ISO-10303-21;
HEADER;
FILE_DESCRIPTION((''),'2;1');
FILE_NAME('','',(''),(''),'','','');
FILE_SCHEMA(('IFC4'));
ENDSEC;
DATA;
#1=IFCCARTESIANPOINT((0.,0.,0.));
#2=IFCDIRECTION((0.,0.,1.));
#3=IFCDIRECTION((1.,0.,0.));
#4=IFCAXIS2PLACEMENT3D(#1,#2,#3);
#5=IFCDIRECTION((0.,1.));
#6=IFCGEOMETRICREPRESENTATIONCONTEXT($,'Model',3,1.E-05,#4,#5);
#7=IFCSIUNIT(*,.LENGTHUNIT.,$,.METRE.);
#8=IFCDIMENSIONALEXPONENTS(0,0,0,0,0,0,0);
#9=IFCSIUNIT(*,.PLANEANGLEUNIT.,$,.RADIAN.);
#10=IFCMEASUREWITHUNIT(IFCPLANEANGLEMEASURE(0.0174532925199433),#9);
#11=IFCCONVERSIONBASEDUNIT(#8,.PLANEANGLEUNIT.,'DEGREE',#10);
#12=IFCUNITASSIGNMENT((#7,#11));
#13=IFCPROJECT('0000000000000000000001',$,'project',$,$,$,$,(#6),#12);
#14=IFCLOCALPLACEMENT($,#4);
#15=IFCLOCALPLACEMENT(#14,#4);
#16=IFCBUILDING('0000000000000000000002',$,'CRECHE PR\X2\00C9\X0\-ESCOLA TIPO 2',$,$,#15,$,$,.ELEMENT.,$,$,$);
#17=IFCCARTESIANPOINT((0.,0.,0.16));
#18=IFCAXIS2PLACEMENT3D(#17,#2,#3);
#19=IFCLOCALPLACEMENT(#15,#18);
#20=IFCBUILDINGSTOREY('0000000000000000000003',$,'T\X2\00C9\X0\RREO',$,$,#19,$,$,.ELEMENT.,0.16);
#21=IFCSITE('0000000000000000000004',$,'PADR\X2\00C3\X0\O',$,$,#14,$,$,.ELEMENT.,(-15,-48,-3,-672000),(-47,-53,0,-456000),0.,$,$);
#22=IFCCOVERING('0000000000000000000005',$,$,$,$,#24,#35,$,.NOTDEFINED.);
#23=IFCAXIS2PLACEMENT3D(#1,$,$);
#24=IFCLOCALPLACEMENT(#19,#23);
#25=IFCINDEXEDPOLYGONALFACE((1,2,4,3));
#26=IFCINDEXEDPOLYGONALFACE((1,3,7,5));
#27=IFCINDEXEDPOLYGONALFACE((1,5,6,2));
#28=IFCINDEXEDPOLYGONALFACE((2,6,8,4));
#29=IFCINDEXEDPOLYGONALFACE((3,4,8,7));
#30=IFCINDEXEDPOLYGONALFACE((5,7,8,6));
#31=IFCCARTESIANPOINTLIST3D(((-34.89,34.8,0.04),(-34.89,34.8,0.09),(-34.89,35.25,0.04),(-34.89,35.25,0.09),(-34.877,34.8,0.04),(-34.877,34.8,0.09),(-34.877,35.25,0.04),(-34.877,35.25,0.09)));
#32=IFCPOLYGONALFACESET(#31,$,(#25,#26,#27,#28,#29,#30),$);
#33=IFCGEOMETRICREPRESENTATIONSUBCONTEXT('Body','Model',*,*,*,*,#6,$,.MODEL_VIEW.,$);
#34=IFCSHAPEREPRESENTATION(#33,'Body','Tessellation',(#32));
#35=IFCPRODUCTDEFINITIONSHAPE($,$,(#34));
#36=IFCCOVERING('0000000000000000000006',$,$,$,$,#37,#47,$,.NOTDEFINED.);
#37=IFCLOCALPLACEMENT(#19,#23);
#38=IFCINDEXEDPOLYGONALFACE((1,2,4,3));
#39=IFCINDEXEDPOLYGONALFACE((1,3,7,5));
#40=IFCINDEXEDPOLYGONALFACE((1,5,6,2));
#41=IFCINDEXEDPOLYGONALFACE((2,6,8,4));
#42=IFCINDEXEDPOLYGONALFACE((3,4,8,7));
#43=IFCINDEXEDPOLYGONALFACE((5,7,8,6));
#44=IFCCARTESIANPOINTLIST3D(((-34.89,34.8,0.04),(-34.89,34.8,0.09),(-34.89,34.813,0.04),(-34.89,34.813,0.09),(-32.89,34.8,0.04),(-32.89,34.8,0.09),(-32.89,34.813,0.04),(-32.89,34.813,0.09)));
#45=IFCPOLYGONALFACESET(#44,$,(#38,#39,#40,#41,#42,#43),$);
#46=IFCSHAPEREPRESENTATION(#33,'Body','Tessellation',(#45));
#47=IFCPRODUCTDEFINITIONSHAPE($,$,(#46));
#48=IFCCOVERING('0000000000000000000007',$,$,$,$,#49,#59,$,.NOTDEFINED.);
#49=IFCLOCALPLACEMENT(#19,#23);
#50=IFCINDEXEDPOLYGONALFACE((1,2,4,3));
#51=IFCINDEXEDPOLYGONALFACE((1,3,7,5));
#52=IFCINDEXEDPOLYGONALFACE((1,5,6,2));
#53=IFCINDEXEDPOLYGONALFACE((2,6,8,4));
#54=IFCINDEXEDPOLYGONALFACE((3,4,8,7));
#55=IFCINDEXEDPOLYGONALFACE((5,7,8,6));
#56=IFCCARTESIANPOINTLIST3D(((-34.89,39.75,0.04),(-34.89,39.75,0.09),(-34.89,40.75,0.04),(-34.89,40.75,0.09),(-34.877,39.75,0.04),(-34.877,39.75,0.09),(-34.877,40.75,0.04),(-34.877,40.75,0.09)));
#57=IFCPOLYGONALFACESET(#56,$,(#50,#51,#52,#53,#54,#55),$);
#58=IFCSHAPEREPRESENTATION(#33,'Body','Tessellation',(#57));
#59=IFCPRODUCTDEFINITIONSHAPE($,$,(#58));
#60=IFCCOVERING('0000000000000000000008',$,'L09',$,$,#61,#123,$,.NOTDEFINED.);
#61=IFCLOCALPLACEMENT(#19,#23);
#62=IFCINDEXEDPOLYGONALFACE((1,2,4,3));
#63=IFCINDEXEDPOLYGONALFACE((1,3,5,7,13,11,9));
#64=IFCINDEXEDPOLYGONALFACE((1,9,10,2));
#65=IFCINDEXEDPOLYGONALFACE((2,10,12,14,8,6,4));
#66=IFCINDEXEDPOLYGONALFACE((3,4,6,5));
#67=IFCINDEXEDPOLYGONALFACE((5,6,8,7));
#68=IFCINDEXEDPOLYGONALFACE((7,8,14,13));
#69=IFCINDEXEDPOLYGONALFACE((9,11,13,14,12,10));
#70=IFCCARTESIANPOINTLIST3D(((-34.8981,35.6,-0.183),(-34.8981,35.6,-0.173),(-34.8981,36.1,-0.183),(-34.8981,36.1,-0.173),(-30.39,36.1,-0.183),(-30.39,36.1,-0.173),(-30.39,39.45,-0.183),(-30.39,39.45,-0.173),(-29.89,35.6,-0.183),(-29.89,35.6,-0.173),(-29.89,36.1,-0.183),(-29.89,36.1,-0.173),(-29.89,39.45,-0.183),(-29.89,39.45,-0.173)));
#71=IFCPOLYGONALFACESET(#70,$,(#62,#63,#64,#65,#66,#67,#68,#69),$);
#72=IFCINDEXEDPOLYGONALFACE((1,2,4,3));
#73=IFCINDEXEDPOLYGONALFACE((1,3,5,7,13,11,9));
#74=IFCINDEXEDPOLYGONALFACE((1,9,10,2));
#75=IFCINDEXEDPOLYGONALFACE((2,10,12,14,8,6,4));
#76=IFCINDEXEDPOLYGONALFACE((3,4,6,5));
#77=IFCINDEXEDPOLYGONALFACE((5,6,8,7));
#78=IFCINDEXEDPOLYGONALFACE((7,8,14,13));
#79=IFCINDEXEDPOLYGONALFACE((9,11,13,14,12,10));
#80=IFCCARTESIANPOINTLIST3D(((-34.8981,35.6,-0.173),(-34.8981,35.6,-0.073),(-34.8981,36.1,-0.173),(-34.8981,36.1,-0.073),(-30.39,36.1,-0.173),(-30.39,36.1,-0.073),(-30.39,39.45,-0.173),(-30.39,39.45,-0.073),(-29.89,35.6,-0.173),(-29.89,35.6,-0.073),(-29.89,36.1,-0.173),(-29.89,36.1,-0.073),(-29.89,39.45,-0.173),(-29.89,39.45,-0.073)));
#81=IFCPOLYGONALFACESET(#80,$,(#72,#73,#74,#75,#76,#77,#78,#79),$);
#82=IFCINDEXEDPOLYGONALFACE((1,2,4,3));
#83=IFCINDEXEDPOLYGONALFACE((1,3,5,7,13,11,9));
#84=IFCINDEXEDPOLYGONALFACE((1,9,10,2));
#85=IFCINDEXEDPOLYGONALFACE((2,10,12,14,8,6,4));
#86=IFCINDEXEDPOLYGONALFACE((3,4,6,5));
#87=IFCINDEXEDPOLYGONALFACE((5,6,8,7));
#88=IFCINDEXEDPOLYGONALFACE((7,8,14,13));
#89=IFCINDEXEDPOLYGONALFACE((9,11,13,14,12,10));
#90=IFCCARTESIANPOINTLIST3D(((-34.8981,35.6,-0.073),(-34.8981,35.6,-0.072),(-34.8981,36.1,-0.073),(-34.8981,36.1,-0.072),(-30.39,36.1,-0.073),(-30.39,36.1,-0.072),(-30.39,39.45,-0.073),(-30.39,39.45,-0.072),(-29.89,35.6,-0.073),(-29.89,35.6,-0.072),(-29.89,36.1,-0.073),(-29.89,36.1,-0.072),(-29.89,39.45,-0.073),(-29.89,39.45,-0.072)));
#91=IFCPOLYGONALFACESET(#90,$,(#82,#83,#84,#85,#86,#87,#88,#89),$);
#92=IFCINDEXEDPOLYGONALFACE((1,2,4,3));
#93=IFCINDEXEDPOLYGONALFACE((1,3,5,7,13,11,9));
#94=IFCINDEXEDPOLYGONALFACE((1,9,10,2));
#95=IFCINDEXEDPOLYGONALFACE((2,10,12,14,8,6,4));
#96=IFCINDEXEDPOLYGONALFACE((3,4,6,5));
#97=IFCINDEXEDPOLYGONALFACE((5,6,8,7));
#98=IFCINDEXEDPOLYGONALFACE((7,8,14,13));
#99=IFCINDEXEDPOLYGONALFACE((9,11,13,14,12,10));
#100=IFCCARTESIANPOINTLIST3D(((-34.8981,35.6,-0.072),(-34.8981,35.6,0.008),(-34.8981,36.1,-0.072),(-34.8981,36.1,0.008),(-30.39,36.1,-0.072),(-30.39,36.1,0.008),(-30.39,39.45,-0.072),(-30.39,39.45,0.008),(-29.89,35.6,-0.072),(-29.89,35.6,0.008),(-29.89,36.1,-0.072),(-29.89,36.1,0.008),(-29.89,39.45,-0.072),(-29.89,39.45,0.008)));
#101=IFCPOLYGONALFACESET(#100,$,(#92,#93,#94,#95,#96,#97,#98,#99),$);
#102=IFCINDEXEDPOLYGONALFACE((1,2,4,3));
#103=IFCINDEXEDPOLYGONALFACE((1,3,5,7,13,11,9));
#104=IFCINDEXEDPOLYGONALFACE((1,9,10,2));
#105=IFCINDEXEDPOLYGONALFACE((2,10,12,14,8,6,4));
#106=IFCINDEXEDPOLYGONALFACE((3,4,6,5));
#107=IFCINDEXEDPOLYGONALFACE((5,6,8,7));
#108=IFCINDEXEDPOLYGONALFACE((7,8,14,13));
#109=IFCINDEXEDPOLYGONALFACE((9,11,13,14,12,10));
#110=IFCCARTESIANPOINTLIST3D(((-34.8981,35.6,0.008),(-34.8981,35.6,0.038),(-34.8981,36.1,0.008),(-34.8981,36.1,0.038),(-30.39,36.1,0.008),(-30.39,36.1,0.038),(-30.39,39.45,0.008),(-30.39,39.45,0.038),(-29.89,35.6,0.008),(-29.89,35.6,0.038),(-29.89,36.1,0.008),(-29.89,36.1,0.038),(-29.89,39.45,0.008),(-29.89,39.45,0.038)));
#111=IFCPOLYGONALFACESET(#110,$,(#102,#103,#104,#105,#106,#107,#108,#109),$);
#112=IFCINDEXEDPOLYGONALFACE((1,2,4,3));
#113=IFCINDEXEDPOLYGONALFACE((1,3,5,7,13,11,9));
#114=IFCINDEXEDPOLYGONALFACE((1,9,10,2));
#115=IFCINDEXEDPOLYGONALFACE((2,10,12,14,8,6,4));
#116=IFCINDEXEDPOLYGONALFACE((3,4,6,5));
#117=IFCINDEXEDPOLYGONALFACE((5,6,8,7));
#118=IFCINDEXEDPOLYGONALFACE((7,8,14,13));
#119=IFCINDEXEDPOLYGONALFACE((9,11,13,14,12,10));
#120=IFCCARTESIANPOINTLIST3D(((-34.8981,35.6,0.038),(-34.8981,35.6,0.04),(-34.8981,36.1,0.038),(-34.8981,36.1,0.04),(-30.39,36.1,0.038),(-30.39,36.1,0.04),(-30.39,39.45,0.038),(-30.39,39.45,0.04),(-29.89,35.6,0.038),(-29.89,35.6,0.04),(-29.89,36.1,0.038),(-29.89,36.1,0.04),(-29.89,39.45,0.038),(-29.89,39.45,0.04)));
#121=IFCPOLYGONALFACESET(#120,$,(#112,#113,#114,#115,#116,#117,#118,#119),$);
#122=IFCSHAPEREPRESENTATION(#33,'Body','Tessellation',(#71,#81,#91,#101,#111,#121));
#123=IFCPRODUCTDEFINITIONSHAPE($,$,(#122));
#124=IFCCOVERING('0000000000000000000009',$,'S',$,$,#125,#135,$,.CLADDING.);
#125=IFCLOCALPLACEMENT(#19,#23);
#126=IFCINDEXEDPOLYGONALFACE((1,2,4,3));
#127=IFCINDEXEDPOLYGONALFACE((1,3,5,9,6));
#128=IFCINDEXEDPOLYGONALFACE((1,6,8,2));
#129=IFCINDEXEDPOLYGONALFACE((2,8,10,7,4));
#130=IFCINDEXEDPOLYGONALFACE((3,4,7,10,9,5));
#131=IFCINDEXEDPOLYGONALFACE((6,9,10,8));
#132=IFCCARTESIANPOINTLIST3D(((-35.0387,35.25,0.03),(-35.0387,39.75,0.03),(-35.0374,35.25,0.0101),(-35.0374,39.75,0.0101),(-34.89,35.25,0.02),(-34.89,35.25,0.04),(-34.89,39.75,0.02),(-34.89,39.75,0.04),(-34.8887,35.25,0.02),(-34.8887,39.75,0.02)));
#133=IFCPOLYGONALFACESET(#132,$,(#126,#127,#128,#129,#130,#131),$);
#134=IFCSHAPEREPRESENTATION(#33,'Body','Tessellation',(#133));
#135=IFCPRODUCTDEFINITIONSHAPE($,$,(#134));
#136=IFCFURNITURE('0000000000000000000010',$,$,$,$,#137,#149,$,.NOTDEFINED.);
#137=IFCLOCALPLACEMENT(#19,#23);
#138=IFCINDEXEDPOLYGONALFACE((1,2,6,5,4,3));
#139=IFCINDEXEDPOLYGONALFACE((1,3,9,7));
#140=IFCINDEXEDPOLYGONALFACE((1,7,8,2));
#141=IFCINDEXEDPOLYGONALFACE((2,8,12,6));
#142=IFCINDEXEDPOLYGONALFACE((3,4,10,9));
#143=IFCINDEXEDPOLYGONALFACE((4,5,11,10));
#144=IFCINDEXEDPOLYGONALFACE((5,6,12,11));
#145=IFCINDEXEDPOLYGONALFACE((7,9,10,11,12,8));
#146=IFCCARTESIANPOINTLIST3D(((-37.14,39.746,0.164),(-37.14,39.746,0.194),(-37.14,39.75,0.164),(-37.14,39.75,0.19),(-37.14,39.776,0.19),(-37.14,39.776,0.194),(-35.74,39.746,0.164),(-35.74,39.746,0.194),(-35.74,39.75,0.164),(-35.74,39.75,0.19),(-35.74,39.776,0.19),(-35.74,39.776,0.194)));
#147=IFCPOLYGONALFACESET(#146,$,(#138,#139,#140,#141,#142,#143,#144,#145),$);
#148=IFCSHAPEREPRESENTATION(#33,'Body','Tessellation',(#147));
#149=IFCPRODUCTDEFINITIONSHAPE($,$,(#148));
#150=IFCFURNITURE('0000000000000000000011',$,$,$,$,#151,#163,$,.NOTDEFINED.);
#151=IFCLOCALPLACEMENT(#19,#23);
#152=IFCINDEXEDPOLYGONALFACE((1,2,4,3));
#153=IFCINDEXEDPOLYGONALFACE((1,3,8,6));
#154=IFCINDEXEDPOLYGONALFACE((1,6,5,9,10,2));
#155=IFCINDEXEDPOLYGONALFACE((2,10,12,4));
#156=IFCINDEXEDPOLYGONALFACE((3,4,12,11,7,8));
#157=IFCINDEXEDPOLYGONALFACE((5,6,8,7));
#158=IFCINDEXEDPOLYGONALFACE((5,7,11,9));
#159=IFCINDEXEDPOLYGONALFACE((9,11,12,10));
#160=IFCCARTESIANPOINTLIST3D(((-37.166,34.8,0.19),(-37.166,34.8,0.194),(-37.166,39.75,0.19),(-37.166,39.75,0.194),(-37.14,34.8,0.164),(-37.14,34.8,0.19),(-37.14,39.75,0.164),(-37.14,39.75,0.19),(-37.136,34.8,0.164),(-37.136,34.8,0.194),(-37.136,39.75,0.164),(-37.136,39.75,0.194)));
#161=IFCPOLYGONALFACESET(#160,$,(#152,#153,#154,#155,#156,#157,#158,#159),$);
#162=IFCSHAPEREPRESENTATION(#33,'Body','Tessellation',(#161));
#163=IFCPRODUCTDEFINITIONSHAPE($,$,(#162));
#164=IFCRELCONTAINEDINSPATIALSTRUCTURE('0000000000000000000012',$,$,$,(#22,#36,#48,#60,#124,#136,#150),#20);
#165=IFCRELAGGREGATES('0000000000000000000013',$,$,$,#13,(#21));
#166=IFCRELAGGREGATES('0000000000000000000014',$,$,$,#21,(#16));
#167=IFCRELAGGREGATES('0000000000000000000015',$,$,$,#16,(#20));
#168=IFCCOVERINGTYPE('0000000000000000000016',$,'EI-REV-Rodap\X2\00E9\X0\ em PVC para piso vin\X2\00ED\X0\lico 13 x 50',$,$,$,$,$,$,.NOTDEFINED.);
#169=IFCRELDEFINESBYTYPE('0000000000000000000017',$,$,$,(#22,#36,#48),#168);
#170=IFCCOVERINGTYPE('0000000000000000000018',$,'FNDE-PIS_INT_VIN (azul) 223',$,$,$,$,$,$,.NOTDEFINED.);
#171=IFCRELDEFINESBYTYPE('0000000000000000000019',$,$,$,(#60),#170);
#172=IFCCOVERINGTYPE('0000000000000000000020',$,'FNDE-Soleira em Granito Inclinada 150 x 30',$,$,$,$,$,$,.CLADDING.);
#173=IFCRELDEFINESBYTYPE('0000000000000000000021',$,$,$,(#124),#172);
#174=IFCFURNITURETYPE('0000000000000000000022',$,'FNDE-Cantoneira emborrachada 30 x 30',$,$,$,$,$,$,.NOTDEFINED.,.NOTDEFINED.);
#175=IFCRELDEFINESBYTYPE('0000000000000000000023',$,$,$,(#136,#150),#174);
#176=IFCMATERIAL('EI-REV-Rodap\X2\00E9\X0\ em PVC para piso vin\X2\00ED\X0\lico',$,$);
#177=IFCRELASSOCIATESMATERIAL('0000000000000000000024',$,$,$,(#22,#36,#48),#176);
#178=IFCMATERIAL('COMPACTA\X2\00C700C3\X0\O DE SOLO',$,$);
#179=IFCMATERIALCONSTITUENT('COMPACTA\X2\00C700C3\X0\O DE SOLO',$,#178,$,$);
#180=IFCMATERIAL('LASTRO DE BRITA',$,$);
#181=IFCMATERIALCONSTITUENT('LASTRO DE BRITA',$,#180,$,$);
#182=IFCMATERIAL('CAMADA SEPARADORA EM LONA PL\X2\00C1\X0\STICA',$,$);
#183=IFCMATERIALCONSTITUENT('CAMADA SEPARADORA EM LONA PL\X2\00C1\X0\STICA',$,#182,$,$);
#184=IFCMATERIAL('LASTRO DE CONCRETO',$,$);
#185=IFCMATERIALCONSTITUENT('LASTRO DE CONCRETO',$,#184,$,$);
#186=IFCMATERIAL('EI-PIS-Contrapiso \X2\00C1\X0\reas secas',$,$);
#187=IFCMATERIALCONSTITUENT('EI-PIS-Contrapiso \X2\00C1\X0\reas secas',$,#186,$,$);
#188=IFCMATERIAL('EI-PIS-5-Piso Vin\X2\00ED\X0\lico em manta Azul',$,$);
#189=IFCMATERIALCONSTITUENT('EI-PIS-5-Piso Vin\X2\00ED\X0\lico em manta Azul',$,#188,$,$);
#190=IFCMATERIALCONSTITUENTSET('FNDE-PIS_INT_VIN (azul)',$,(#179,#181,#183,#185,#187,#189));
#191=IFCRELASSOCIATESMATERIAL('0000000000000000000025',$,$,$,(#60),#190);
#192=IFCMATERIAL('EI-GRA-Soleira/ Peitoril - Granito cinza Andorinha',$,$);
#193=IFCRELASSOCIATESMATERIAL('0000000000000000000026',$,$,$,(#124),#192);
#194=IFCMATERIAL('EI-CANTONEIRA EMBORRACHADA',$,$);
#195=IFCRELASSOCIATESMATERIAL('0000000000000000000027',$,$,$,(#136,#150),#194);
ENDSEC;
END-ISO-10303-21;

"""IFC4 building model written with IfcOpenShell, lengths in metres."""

from ifc_helpers import new_model, entity, si_unit, converted_unit, direction, frame, frame_2d, origin_with_axes, place, context, subcontext, project, spatial, line, indexed_curve, rectangle, outline, extrude, material, constituent, constituent_set, material_profile, profile_set, type_object, element, save


model = new_model("IFC4")

# Units and contexts
model_context = context("Model", 3, precision=1e-05, world=origin_with_axes(), true_north=direction((0.0, 1.0)))
body_context = subcontext(model_context, "Body", "Model", "MODEL_VIEW")
ifc_project = project(units=[si_unit("LENGTHUNIT", "METRE"), converted_unit("PLANEANGLEUNIT", "DEGREE", entity("IfcPlaneAngleMeasure", 0.0174532925199433), si_unit("PLANEANGLEUNIT", "RADIAN"), dimensions=[0, 0, 0, 0, 0, 0, 0])], contexts=[model_context])

# Site, building, storey
site_placement = place(None, origin_with_axes())
site = spatial("IfcSite", under=ifc_project, at=site_placement, Name="PADRÃO", CompositionType="ELEMENT", RefLatitude=(-15, -48, -3, -672000), RefLongitude=(-47, -53, 0, -456000), RefElevation=0.0)
building_placement = place(site_placement, origin_with_axes())
building = spatial("IfcBuilding", under=site, at=building_placement, Name="CRECHE PRÉ-ESCOLA TIPO 2", CompositionType="ELEMENT")
storey_placement = place(building_placement, frame((0.0, 0.0, 0.16), z_axis=(0.0, 0.0, 1.0), x_axis=(1.0, 0.0, 0.0)))
storey = spatial("IfcBuildingStorey", under=building, at=storey_placement, Name="TÉRREO", CompositionType="ELEMENT", Elevation=0.16)

# Coverings
ifc_material_1 = material(Name="COMPACTAÇÃO DE SOLO")
ifc_material_2 = material(Name="LASTRO DE BRITA")
ifc_material_3 = material(Name="CAMADA SEPARADORA EM LONA PLÁSTICA")
ifc_material_4 = material(Name="LASTRO DE CONCRETO")
ifc_material_5 = material(Name="EI-PIS-Contrapiso Áreas secas")
ifc_material_6 = material(Name="EI-REV-Rodapé em PVC para piso vinílico")
covering_type_1 = type_object("IfcCoveringType", Name="EI-REV-Rodapé em PVC para piso vinílico 13 x 50", PredefinedType="NOTDEFINED")
covering_1_placement = place(storey_placement, frame((-34.89, 35.25, 0.04), z_axis=(0.0, 0.0, 1.0), x_axis=(-1.0, 0.0, 0.0)))
element("IfcCovering", 1, at=covering_1_placement, inside=storey, type_object=covering_type_1, material=ifc_material_6, PredefinedType="NOTDEFINED", context=body_context, shape_type="SweptSolid", body=[
    extrude(rectangle(XDim=0.05, YDim=0.013, at=frame_2d((0.025, -0.0065), x_axis=(1.0, 0.0))), frame((0.0, 0.0, 0.0), z_axis=(0.0, 1.0, 0.0), x_axis=(0.0, 0.0, 1.0)), (0.0, 0.0, 1.0), 0.45),
])
covering_2_placement = place(storey_placement, frame((-34.89, 34.8, 0.04), z_axis=(0.0, 0.0, 1.0), x_axis=(0.0, -1.0, 0.0)))
element("IfcCovering", 2, at=covering_2_placement, inside=storey, type_object=covering_type_1, material=ifc_material_6, PredefinedType="NOTDEFINED", context=body_context, shape_type="SweptSolid", body=[
    extrude(rectangle(XDim=0.05, YDim=0.013, at=frame_2d((0.025, -0.0065), x_axis=(1.0, 0.0))), frame((0.0, 0.0, 0.0), z_axis=(0.0, 1.0, 0.0), x_axis=(0.0, 0.0, 1.0)), (0.0, 0.0, 1.0), 2.0),
])
covering_3_placement = place(storey_placement, frame((-34.89, 40.75, 0.04), z_axis=(0.0, 0.0, 1.0), x_axis=(-1.0, 0.0, 0.0)))
element("IfcCovering", 3, at=covering_3_placement, inside=storey, type_object=covering_type_1, material=ifc_material_6, PredefinedType="NOTDEFINED", context=body_context, shape_type="SweptSolid", body=[
    extrude(rectangle(XDim=0.05, YDim=0.013, at=frame_2d((0.025, -0.0065), x_axis=(1.0, 0.0))), frame((0.0, 0.0, 0.0), z_axis=(0.0, 1.0, 0.0), x_axis=(0.0, 0.0, 1.0)), (0.0, 0.0, 1.0), 1.0),
])
ifc_constituent_1 = constituent(ifc_material_1, Name="COMPACTAÇÃO DE SOLO")
ifc_constituent_2 = constituent(ifc_material_2, Name="LASTRO DE BRITA")
ifc_constituent_3 = constituent(ifc_material_3, Name="CAMADA SEPARADORA EM LONA PLÁSTICA")
ifc_constituent_4 = constituent(ifc_material_4, Name="LASTRO DE CONCRETO")
ifc_constituent_5 = constituent(ifc_material_5, Name="EI-PIS-Contrapiso Áreas secas")
ifc_material_7 = material(Name="EI-PIS-5-Piso Vinílico em manta Azul")
ifc_constituent_6 = constituent(ifc_material_7, Name="EI-PIS-5-Piso Vinílico em manta Azul")
ifc_constituent_set_1 = constituent_set(constituents=[ifc_constituent_1, ifc_constituent_2, ifc_constituent_3, ifc_constituent_4, ifc_constituent_5, ifc_constituent_6], Name="FNDE-PIS_INT_VIN (azul)")
covering_type_2 = type_object("IfcCoveringType", Name="FNDE-PIS_INT_VIN (azul) 223", PredefinedType="NOTDEFINED")
covering_4_placement = place(storey_placement, frame((-34.8981, 35.6, 0.04), z_axis=(0.0, 0.0, 1.0), x_axis=(1.0, 0.0, 0.0)))
element("IfcCovering", 4, at=covering_4_placement, inside=storey, type_object=covering_type_2, material=ifc_constituent_set_1, Name="L09", PredefinedType="NOTDEFINED", context=body_context, shape_type="SweptSolid", body=[
    extrude(outline(indexed_curve([(0.0, 0.0), (5.0081, 0.0), (5.0081, 0.5), (5.0081, 3.85), (4.508, 3.85), (4.508, 0.5), (0.0, 0.5)], segments=[line(1, 2, 3, 4, 5, 6, 7, 1)])), frame((0.0, 0.0, -0.223), z_axis=(0.0, 0.0, 1.0), x_axis=(1.0, 0.0, 0.0)), (0.0, 0.0, 1.0), 0.01),
    extrude(outline(indexed_curve([(0.0, 0.0), (5.0081, 0.0), (5.0081, 0.5), (5.0081, 3.85), (4.508, 3.85), (4.508, 0.5), (0.0, 0.5)], segments=[line(1, 2, 3, 4, 5, 6, 7, 1)])), frame((0.0, 0.0, -0.213), z_axis=(0.0, 0.0, 1.0), x_axis=(1.0, 0.0, 0.0)), (0.0, 0.0, 1.0), 0.1),
    extrude(outline(indexed_curve([(0.0, 0.0), (5.0081, 0.0), (5.0081, 0.5), (5.0081, 3.85), (4.508, 3.85), (4.508, 0.5), (0.0, 0.5)], segments=[line(1, 2, 3, 4, 5, 6, 7, 1)])), frame((0.0, 0.0, -0.113), z_axis=(0.0, 0.0, 1.0), x_axis=(1.0, 0.0, 0.0)), (0.0, 0.0, 1.0), 0.001),
    extrude(outline(indexed_curve([(0.0, 0.0), (5.0081, 0.0), (5.0081, 0.5), (5.0081, 3.85), (4.508, 3.85), (4.508, 0.5), (0.0, 0.5)], segments=[line(1, 2, 3, 4, 5, 6, 7, 1)])), frame((0.0, 0.0, -0.112), z_axis=(0.0, 0.0, 1.0), x_axis=(1.0, 0.0, 0.0)), (0.0, 0.0, 1.0), 0.08),
    extrude(outline(indexed_curve([(0.0, 0.0), (5.0081, 0.0), (5.0081, 0.5), (5.0081, 3.85), (4.508, 3.85), (4.508, 0.5), (0.0, 0.5)], segments=[line(1, 2, 3, 4, 5, 6, 7, 1)])), frame((0.0, 0.0, -0.032), z_axis=(0.0, 0.0, 1.0), x_axis=(1.0, 0.0, 0.0)), (0.0, 0.0, 1.0), 0.03),
    extrude(outline(indexed_curve([(0.0, 0.0), (5.0081, 0.0), (5.0081, 0.5), (5.0081, 3.85), (4.508, 3.85), (4.508, 0.5), (0.0, 0.5)], segments=[line(1, 2, 3, 4, 5, 6, 7, 1)])), frame((0.0, 0.0, -0.002), z_axis=(0.0, 0.0, 1.0), x_axis=(1.0, 0.0, 0.0)), (0.0, 0.0, 1.0), 0.002),
])
ifc_material_8 = material(Name="EI-GRA-Soleira/ Peitoril - Granito cinza Andorinha")
ifc_material_profile_1 = material_profile(ifc_material_8, outline(indexed_curve([(-0.0013, 0.02), (0.0, 0.02), (0.1474, 0.0101), (0.1487, 0.03), (0.0, 0.04)], segments=[line(1, 2, 3, 4, 5, 1)])), Name="EI-GRA-Soleira/ Peitoril - Granito cinza Andorinha")
ifc_profile_set_1 = profile_set([ifc_material_profile_1], Name="FNDE-Soleira em Granito Inclinada")
covering_type_3 = type_object("IfcCoveringType", Name="FNDE-Soleira em Granito Inclinada 150 x 30", PredefinedType="CLADDING")
covering_5_placement = place(storey_placement, frame((-34.89, 39.75, 0.0), z_axis=(0.0, 0.0, 1.0), x_axis=(-1.0, 0.0, 0.0)))
element("IfcCovering", 5, at=covering_5_placement, inside=storey, type_object=covering_type_3, material=ifc_profile_set_1, Name="S", PredefinedType="CLADDING", context=body_context, shape_type="SweptSolid", body=[
    extrude(outline(indexed_curve([(-0.0013, 0.02), (0.0, 0.02), (0.1474, 0.0101), (0.1487, 0.03), (0.0, 0.04)], segments=[line(1, 2, 3, 4, 5, 1)])), frame((0.0, 4.5, 0.0), z_axis=(0.0, -1.0, 0.0), x_axis=(1.0, 0.0, 0.0)), (0.0, 0.0, 1.0), 4.5),
])

# Furniture
ifc_material_9 = material(Name="EI-CANTONEIRA EMBORRACHADA")
ifc_material_profile_2 = material_profile(ifc_material_9, outline(indexed_curve([(-0.004, 0.004), (-0.004, -0.026), (0.0, -0.026), (0.0, 0.0), (0.026, 0.0), (0.026, 0.004)], segments=[line(1, 2, 3, 4, 5, 6, 1)])), Name="EI-CANTONEIRA EMBORRACHADA")
ifc_profile_set_2 = profile_set([ifc_material_profile_2], Name="FNDE-Cantoneira emborrachada")
furniture_type = type_object("IfcFurnitureType", Name="FNDE-Cantoneira emborrachada 30 x 30", AssemblyPlace="NOTDEFINED", PredefinedType="NOTDEFINED")
furniture_1_placement = place(storey_placement, frame((-35.74, 39.75, 0.19), z_axis=(0.0, 0.0, 1.0), x_axis=(0.0, 1.0, 0.0)))
element("IfcFurniture", 6, at=furniture_1_placement, inside=storey, type_object=furniture_type, material=ifc_profile_set_2, PredefinedType="NOTDEFINED", context=body_context, shape_type="SweptSolid", body=[
    extrude(outline(indexed_curve([(-0.004, 0.004), (-0.004, -0.026), (0.0, -0.026), (0.0, 0.0), (0.026, 0.0), (0.026, 0.004)], segments=[line(1, 2, 3, 4, 5, 6, 1)])), frame((0.0, 1.4, 0.0), z_axis=(0.0, -1.0, 0.0), x_axis=(1.0, 0.0, 0.0)), (0.0, 0.0, 1.0), 1.4),
])
furniture_2_placement = place(storey_placement, frame((-37.14, 39.75, 0.19), z_axis=(0.0, 0.0, 1.0), x_axis=(-1.0, 0.0, 0.0)))
element("IfcFurniture", 7, at=furniture_2_placement, inside=storey, type_object=furniture_type, material=ifc_profile_set_2, PredefinedType="NOTDEFINED", context=body_context, shape_type="SweptSolid", body=[
    extrude(outline(indexed_curve([(-0.004, 0.004), (-0.004, -0.026), (0.0, -0.026), (0.0, 0.0), (0.026, 0.0), (0.026, 0.004)], segments=[line(1, 2, 3, 4, 5, 6, 1)])), frame((0.0, 4.95, 0.0), z_axis=(0.0, -1.0, 0.0), x_axis=(1.0, 0.0, 0.0)), (0.0, 0.0, 1.0), 4.95),
])

save(model, "model.ifc")
